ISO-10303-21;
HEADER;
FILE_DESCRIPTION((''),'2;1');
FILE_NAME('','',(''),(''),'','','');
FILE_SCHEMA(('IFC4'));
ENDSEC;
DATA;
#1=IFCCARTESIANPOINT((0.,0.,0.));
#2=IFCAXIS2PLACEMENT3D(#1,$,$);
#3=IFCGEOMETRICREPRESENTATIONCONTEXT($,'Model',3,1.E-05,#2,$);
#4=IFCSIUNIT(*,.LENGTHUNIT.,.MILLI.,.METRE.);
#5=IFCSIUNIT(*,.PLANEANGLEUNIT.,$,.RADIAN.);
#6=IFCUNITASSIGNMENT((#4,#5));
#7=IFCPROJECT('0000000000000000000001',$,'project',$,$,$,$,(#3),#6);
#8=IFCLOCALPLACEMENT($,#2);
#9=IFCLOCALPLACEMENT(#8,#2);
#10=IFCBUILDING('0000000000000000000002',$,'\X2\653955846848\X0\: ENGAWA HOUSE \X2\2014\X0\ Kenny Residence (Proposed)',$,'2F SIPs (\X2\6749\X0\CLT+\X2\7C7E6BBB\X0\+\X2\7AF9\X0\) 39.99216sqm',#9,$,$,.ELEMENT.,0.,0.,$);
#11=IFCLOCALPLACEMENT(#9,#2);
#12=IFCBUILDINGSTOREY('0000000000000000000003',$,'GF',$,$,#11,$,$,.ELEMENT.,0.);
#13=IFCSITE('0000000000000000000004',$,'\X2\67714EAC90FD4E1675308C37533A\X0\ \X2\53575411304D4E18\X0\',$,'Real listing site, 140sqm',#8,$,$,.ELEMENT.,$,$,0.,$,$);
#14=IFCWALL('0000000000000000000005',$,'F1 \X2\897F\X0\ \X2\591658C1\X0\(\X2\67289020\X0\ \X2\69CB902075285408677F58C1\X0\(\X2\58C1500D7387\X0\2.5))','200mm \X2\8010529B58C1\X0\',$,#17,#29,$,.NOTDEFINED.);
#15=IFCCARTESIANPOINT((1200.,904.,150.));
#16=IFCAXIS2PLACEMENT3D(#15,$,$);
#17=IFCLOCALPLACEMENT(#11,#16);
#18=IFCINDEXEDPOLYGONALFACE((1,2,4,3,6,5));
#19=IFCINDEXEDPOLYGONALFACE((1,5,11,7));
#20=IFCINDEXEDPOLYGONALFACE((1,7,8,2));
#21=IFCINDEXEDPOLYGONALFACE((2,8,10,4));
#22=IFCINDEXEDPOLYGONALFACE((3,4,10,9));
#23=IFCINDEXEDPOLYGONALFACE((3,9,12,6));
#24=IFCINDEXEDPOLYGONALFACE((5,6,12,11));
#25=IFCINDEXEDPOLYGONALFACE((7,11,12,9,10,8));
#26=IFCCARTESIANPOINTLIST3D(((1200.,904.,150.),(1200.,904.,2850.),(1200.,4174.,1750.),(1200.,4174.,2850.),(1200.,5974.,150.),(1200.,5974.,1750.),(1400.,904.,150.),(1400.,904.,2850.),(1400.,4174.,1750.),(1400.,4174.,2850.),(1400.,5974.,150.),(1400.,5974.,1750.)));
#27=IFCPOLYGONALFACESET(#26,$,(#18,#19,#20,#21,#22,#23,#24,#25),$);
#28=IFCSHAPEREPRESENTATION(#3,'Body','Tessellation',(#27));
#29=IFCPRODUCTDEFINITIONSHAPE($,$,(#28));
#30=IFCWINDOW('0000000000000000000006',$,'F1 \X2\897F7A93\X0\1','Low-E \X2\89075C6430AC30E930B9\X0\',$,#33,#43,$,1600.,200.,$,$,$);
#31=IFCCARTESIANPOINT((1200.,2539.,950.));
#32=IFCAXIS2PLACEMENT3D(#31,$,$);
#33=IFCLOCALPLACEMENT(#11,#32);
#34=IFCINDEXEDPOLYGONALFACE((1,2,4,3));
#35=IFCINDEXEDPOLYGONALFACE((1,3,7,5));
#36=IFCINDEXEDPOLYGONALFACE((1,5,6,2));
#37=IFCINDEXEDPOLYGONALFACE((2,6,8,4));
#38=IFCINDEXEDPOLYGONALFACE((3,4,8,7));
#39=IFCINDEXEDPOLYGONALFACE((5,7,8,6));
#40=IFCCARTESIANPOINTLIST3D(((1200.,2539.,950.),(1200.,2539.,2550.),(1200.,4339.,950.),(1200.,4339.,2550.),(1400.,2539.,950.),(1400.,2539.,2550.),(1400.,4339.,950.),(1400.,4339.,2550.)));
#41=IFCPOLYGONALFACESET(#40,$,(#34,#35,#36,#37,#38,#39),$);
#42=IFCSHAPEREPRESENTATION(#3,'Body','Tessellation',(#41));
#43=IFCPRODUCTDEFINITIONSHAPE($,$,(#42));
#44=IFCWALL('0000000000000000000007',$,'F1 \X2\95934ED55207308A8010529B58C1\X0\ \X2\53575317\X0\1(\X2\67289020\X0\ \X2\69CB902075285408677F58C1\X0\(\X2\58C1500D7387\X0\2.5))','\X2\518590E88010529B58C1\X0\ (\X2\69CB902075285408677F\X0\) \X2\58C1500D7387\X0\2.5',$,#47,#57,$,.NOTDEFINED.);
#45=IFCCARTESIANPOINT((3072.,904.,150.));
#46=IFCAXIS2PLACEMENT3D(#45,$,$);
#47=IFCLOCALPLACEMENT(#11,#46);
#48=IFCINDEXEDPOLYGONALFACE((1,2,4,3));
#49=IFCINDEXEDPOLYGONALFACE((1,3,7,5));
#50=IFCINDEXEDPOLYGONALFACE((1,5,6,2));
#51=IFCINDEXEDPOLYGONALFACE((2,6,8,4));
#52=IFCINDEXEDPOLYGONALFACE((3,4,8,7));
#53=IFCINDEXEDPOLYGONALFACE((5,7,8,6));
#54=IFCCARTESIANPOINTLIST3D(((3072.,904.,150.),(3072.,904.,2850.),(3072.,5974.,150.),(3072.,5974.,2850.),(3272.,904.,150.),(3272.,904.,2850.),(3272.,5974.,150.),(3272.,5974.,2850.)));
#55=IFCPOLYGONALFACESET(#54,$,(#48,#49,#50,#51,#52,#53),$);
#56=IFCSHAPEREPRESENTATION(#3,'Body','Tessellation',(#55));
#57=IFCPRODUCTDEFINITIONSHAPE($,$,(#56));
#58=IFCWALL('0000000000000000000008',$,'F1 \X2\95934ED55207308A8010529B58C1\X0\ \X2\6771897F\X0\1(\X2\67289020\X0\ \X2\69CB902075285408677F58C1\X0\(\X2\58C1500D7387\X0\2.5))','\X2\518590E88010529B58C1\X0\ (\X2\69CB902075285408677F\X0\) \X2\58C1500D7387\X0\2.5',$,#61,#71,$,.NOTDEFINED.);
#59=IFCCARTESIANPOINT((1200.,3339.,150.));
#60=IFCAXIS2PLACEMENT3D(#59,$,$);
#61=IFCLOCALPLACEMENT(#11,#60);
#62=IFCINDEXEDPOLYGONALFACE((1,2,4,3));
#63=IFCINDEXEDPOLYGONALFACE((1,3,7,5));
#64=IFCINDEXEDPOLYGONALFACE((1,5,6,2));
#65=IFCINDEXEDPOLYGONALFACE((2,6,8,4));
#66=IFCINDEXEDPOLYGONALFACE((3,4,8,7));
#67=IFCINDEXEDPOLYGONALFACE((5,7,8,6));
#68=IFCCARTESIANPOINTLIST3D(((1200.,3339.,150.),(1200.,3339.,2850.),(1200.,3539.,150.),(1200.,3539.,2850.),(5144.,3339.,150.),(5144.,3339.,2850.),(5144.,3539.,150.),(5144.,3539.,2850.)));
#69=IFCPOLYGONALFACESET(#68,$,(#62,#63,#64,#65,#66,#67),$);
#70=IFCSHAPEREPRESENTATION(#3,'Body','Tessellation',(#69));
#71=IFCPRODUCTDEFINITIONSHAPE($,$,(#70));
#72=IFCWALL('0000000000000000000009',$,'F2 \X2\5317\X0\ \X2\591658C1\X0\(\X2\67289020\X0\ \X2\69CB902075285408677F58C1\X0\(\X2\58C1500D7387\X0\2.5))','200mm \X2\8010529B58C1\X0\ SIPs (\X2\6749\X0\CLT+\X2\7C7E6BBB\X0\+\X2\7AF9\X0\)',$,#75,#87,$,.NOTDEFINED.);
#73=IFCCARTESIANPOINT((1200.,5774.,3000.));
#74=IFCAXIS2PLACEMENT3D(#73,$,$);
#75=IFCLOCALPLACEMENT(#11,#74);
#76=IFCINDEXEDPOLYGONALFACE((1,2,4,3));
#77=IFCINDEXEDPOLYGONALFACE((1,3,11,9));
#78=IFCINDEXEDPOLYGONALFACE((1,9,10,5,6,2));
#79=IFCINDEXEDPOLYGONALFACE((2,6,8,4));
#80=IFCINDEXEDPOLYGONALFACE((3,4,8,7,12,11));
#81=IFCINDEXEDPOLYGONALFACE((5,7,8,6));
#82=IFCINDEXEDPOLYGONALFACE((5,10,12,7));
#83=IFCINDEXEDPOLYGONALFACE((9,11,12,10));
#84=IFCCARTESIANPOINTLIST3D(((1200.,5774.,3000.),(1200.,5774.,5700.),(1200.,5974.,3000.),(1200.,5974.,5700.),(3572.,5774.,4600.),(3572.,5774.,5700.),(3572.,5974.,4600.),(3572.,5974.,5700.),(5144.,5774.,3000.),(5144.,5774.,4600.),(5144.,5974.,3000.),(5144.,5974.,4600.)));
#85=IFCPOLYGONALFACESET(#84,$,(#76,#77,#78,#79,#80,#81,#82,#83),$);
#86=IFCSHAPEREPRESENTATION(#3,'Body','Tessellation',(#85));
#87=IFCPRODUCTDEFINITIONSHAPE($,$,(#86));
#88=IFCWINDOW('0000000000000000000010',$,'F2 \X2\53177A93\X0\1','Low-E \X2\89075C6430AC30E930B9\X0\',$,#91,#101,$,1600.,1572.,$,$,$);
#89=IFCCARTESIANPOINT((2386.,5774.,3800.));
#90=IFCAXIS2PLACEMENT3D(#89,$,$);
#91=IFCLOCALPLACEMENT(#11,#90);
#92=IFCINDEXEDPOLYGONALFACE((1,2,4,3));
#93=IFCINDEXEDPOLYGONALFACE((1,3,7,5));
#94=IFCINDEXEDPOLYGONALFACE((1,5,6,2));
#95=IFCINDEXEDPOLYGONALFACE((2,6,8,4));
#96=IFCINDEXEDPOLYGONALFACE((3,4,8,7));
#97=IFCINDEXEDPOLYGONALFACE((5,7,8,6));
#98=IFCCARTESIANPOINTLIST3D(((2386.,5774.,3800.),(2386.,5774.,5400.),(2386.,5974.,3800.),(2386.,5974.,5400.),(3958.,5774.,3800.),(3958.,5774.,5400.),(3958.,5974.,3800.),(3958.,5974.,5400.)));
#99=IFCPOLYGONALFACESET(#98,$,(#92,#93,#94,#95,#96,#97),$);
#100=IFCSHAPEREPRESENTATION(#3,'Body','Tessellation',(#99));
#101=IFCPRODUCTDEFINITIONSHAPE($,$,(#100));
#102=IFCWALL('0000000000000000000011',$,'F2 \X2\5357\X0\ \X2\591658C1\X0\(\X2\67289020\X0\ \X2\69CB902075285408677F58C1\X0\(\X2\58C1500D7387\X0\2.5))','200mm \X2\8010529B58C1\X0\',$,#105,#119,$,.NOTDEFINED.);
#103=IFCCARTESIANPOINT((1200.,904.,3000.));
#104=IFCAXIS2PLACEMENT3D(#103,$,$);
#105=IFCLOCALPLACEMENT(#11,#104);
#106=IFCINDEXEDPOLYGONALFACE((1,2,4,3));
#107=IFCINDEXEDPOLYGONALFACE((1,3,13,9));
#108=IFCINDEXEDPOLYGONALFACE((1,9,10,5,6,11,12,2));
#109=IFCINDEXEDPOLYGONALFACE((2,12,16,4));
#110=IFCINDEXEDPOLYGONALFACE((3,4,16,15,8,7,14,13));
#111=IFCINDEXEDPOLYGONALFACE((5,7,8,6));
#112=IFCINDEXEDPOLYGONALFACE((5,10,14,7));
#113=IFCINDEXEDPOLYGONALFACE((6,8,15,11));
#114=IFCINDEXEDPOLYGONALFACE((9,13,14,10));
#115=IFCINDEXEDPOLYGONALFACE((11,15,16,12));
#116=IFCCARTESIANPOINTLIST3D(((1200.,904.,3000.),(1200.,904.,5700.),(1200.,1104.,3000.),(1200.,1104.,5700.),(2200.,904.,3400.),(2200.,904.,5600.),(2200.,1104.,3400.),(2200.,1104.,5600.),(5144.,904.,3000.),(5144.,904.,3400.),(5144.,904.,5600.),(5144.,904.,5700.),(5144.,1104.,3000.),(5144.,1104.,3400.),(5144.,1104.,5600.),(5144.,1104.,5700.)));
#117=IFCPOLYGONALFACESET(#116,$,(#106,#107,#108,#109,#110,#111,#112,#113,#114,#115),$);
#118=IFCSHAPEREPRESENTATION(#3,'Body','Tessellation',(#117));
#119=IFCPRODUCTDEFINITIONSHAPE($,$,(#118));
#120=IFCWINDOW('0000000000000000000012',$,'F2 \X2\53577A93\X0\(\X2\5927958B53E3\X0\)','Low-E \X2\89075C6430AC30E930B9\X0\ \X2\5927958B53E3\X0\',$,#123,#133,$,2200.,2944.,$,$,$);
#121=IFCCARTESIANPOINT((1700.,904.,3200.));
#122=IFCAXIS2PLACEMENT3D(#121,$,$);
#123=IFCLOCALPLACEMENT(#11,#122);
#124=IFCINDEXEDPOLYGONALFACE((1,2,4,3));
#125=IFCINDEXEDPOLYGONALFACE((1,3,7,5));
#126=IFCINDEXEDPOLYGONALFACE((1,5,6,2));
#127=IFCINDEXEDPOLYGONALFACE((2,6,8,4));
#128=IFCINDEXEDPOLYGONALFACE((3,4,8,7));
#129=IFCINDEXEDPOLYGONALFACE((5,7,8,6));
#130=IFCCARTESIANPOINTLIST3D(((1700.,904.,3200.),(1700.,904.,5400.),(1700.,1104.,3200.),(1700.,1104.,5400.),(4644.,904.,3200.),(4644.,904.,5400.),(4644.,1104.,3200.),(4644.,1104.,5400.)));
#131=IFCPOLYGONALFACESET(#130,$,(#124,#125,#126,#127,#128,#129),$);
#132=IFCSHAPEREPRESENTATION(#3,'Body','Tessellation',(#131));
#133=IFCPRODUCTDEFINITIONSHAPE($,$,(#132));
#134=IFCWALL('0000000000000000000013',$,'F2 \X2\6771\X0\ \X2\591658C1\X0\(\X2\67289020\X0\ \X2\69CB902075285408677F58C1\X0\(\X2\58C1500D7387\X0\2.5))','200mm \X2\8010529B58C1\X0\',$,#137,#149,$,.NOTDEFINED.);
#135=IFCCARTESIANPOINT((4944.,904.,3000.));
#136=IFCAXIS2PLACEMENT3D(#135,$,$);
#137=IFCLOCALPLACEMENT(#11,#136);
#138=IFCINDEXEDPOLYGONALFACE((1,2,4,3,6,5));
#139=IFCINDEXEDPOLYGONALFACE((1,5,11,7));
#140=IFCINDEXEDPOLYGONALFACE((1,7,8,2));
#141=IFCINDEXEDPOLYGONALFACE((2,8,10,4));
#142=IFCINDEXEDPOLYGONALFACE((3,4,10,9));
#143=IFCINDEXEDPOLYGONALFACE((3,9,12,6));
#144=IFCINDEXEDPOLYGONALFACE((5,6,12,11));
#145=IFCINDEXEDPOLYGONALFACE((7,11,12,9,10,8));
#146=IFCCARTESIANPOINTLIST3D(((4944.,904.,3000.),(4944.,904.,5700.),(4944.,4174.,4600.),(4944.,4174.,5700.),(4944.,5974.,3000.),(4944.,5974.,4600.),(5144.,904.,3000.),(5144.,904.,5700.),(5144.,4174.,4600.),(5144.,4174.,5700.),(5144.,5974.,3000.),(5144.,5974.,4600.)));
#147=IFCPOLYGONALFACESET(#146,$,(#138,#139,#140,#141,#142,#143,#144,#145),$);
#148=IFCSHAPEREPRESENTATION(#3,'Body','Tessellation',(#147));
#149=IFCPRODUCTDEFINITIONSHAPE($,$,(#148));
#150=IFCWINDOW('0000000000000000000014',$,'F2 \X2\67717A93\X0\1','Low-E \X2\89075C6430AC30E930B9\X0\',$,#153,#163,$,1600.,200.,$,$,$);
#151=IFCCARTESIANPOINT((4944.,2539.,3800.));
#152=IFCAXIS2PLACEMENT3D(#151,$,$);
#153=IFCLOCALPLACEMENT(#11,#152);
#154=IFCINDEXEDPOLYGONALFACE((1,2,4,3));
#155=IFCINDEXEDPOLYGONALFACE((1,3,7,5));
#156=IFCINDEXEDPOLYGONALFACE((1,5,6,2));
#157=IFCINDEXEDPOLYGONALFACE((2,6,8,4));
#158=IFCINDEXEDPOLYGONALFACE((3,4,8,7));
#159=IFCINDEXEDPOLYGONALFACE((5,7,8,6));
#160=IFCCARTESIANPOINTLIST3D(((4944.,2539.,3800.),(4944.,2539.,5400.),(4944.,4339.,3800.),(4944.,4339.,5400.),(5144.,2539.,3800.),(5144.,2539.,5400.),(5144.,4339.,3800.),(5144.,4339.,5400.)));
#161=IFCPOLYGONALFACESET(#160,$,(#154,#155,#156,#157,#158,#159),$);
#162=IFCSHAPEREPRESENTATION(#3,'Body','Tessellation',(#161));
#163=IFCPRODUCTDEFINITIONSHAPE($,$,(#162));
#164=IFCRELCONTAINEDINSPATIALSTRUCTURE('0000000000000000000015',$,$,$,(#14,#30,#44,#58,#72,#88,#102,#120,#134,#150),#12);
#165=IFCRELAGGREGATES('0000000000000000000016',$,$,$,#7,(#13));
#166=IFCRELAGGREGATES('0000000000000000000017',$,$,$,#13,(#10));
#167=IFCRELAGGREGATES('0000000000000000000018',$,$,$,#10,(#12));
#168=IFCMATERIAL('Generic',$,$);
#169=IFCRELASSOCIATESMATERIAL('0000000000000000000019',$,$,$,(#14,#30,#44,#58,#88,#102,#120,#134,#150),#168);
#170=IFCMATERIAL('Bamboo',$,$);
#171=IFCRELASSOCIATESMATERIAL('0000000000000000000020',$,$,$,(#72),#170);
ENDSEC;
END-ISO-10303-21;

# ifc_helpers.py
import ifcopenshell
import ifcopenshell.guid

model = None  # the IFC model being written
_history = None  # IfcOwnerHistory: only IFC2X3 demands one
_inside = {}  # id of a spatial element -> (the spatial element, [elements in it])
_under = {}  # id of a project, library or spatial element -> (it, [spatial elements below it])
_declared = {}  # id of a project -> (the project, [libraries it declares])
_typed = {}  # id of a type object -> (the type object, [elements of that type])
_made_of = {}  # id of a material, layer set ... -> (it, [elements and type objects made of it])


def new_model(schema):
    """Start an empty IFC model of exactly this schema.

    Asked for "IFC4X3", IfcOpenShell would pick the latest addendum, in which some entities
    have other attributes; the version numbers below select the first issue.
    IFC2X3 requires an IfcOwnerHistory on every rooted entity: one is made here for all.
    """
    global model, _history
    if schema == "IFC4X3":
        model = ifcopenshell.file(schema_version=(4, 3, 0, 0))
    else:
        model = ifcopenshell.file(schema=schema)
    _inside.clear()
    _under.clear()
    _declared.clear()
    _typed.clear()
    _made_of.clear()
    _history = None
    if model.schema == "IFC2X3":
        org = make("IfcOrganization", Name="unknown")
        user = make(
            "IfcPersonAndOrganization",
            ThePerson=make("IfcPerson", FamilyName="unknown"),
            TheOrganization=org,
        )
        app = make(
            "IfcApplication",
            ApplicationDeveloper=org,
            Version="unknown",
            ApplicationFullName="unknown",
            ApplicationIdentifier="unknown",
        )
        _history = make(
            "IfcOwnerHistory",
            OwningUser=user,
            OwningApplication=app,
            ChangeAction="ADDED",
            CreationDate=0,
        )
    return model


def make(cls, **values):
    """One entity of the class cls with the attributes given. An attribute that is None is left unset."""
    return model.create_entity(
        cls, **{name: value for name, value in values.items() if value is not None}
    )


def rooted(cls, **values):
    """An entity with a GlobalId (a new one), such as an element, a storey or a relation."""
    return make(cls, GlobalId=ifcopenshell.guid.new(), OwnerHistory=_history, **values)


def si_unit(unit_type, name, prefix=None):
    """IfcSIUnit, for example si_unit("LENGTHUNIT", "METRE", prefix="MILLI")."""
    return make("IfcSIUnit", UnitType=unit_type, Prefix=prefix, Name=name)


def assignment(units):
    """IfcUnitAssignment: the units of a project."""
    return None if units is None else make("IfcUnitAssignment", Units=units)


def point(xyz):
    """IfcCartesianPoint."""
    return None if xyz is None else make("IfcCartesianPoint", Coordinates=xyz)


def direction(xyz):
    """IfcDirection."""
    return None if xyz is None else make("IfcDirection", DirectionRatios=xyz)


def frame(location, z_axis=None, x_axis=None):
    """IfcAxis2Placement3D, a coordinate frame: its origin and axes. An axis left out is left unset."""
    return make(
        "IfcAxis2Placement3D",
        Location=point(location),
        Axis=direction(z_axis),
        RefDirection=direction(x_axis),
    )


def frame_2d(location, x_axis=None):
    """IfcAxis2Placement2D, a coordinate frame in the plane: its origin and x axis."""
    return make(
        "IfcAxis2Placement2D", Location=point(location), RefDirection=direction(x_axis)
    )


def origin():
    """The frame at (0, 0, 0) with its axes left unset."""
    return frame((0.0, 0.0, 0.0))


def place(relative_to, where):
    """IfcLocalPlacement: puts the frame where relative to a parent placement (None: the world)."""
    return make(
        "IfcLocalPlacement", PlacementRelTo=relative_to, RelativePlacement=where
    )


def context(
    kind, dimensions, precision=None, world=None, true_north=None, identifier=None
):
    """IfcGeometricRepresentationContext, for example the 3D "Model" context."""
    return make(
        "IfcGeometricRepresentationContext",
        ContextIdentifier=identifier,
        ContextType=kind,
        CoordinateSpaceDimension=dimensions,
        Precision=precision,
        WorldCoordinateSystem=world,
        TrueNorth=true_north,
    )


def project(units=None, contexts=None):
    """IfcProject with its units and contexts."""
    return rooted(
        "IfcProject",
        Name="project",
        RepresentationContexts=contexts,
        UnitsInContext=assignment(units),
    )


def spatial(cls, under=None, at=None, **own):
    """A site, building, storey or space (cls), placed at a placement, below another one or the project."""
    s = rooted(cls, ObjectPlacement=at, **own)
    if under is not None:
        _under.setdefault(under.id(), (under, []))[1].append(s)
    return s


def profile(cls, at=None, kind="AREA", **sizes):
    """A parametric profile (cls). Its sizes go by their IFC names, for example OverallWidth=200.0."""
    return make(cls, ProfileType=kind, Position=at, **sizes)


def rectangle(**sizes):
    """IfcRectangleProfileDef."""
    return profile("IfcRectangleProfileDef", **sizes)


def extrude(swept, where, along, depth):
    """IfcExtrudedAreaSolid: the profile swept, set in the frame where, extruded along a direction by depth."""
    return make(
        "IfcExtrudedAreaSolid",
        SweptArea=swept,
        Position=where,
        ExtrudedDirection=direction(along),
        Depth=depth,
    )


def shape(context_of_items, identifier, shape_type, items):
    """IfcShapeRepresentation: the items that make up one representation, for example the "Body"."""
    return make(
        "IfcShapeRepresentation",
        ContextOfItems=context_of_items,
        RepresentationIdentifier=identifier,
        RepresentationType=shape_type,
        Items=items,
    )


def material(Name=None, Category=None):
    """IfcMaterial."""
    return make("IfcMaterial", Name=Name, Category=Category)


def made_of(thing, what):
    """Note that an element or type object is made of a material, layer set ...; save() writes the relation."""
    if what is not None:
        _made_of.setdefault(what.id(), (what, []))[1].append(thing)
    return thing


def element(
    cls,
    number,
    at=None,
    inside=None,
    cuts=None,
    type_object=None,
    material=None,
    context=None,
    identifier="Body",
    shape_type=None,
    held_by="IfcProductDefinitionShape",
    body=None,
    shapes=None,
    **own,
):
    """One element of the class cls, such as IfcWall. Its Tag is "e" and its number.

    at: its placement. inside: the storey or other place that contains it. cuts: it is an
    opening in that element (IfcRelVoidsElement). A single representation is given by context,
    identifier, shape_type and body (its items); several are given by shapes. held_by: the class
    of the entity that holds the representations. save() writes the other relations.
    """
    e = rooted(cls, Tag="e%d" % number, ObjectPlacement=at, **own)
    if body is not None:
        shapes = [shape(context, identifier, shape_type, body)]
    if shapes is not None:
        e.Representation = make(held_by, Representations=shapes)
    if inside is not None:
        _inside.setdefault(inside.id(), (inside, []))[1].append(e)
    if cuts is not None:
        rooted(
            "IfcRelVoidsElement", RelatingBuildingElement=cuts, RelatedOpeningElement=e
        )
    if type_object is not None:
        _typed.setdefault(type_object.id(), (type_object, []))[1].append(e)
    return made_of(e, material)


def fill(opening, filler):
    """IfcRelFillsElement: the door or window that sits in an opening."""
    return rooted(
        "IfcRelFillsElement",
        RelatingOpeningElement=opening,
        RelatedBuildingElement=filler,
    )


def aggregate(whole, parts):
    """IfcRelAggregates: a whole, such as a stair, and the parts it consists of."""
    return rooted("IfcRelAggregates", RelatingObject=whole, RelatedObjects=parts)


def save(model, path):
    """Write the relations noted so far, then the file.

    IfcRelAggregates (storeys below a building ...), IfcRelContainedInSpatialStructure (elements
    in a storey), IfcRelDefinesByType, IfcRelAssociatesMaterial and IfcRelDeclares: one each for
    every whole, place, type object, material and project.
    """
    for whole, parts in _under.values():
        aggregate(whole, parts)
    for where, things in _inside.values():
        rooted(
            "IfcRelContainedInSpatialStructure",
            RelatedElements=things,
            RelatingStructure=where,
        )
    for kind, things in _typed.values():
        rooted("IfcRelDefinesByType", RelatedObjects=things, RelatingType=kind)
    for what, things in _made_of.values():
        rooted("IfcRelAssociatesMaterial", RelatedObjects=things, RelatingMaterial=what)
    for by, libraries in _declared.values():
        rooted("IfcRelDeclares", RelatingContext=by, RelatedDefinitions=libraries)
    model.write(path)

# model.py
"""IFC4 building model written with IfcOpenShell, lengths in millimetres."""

from ifc_helpers import new_model, si_unit, frame, frame_2d, origin, place, context, project, spatial, rectangle, extrude, material, element, fill, save


model = new_model("IFC4")

# Units and contexts
model_context = context("Model", 3, precision=1e-05, world=origin())
ifc_project = project(units=[si_unit("LENGTHUNIT", "METRE", prefix="MILLI"), si_unit("PLANEANGLEUNIT", "RADIAN")], contexts=[model_context])

# Site, building, storey
site_placement = place(None, origin())
site = spatial("IfcSite", under=ifc_project, at=site_placement, Name="東京都世田谷区 南向き丘", ObjectType="Real listing site, 140sqm", CompositionType="ELEMENT", RefElevation=0.0)
building_placement = place(site_placement, origin())
building = spatial("IfcBuilding", under=site, at=building_placement, Name="改善案: ENGAWA HOUSE — Kenny Residence (Proposed)", ObjectType="2F SIPs (杉CLT+籾殻+竹) 39.99216sqm", CompositionType="ELEMENT", ElevationOfRefHeight=0.0, ElevationOfTerrain=0.0)
storey_placement = place(building_placement, origin())
storey = spatial("IfcBuildingStorey", under=building, at=storey_placement, Name="GF", CompositionType="ELEMENT", Elevation=0.0)

# Shared definitions
ifc_material_1 = material(Name="Generic")

# Shared definitions
ifc_material_2 = material(Name="Bamboo")

# Wall, opening, window
wall_1_placement = place(storey_placement, frame((1200.0, 904.0, 150.0)))
wall_1 = element("IfcWall", 1, at=wall_1_placement, inside=storey, material=ifc_material_1, Name="F1 西 外壁(木造 構造用合板壁(壁倍率2.5))", Description="200mm 耐力壁", PredefinedType="NOTDEFINED", context=model_context, shape_type="SweptSolid", body=[
    extrude(rectangle(XDim=200.0, YDim=5070.0, at=frame_2d((100.0, 2535.0))), frame((1200.0, 904.0, 150.0)), (0.0, 0.0, 1.0), 2700.0),
])
opening_1_placement = place(storey_placement, frame((1200.0, 2539.0, 950.0)))
opening_1 = element("IfcOpeningElement", 2, at=opening_1_placement, cuts=wall_1, PredefinedType="NOTDEFINED", context=model_context, shape_type="SweptSolid", body=[
    extrude(rectangle(XDim=200.0, YDim=1800.0, at=frame_2d((100.0, 900.0))), frame((1200.0, 2539.0, 950.0)), (0.0, 0.0, 1.0), 1600.0),
])
window_1_placement = place(storey_placement, frame((1200.0, 2539.0, 950.0)))
window_1 = element("IfcWindow", 3, at=window_1_placement, inside=storey, material=ifc_material_1, Name="F1 西窓1", Description="Low-E 複層ガラス", OverallHeight=1600.0, OverallWidth=200.0, context=model_context, shape_type="SweptSolid", body=[
    extrude(rectangle(XDim=200.0, YDim=1800.0, at=frame_2d((100.0, 900.0))), frame((1200.0, 2539.0, 950.0)), (0.0, 0.0, 1.0), 1600.0),
])
fill(opening_1, window_1)

# Walls
wall_2_placement = place(storey_placement, frame((3072.0, 904.0, 150.0)))
element("IfcWall", 4, at=wall_2_placement, inside=storey, material=ifc_material_1, Name="F1 間仕切り耐力壁 南北1(木造 構造用合板壁(壁倍率2.5))", Description="内部耐力壁 (構造用合板) 壁倍率2.5", PredefinedType="NOTDEFINED", context=model_context, shape_type="SweptSolid", body=[
    extrude(rectangle(XDim=200.0, YDim=5070.0, at=frame_2d((100.0, 2535.0))), frame((3072.0, 904.0, 150.0)), (0.0, 0.0, 1.0), 2700.0),
])
wall_3_placement = place(storey_placement, frame((1200.0, 3339.0, 150.0)))
element("IfcWall", 5, at=wall_3_placement, inside=storey, material=ifc_material_1, Name="F1 間仕切り耐力壁 東西1(木造 構造用合板壁(壁倍率2.5))", Description="内部耐力壁 (構造用合板) 壁倍率2.5", PredefinedType="NOTDEFINED", context=model_context, shape_type="SweptSolid", body=[
    extrude(rectangle(XDim=3944.0, YDim=200.0, at=frame_2d((1972.0, 100.0))), frame((1200.0, 3339.0, 150.0)), (0.0, 0.0, 1.0), 2700.0),
])

# Walls, openings, windows
wall_4_placement = place(storey_placement, frame((1200.0, 5774.0, 3000.0)))
wall_4 = element("IfcWall", 6, at=wall_4_placement, inside=storey, material=ifc_material_2, Name="F2 北 外壁(木造 構造用合板壁(壁倍率2.5))", Description="200mm 耐力壁 SIPs (杉CLT+籾殻+竹)", PredefinedType="NOTDEFINED", context=model_context, shape_type="SweptSolid", body=[
    extrude(rectangle(XDim=3944.0, YDim=200.0, at=frame_2d((1972.0, 100.0))), frame((1200.0, 5774.0, 3000.0)), (0.0, 0.0, 1.0), 2700.0),
])
opening_2_placement = place(storey_placement, frame((2386.0, 5774.0, 3800.0)))
opening_2 = element("IfcOpeningElement", 7, at=opening_2_placement, cuts=wall_4, PredefinedType="NOTDEFINED", context=model_context, shape_type="SweptSolid", body=[
    extrude(rectangle(XDim=1572.0, YDim=200.0, at=frame_2d((786.0, 100.0))), frame((2386.0, 5774.0, 3800.0)), (0.0, 0.0, 1.0), 1600.0),
])
window_2_placement = place(storey_placement, frame((2386.0, 5774.0, 3800.0)))
window_2 = element("IfcWindow", 8, at=window_2_placement, inside=storey, material=ifc_material_1, Name="F2 北窓1", Description="Low-E 複層ガラス", OverallHeight=1600.0, OverallWidth=1572.0, context=model_context, shape_type="SweptSolid", body=[
    extrude(rectangle(XDim=1572.0, YDim=200.0, at=frame_2d((786.0, 100.0))), frame((2386.0, 5774.0, 3800.0)), (0.0, 0.0, 1.0), 1600.0),
])
fill(opening_2, window_2)
wall_5_placement = place(storey_placement, frame((1200.0, 904.0, 3000.0)))
wall_5 = element("IfcWall", 9, at=wall_5_placement, inside=storey, material=ifc_material_1, Name="F2 南 外壁(木造 構造用合板壁(壁倍率2.5))", Description="200mm 耐力壁", PredefinedType="NOTDEFINED", context=model_context, shape_type="SweptSolid", body=[
    extrude(rectangle(XDim=3944.0, YDim=200.0, at=frame_2d((1972.0, 100.0))), frame((1200.0, 904.0, 3000.0)), (0.0, 0.0, 1.0), 2700.0),
])
opening_3_placement = place(storey_placement, frame((1700.0, 904.0, 3200.0)))
opening_3 = element("IfcOpeningElement", 10, at=opening_3_placement, cuts=wall_5, PredefinedType="NOTDEFINED", context=model_context, shape_type="SweptSolid", body=[
    extrude(rectangle(XDim=2944.0, YDim=200.0, at=frame_2d((1472.0, 100.0))), frame((1700.0, 904.0, 3200.0)), (0.0, 0.0, 1.0), 2200.0),
])
window_3_placement = place(storey_placement, frame((1700.0, 904.0, 3200.0)))
window_3 = element("IfcWindow", 11, at=window_3_placement, inside=storey, material=ifc_material_1, Name="F2 南窓(大開口)", Description="Low-E 複層ガラス 大開口", OverallHeight=2200.0, OverallWidth=2944.0, context=model_context, shape_type="SweptSolid", body=[
    extrude(rectangle(XDim=2944.0, YDim=200.0, at=frame_2d((1472.0, 100.0))), frame((1700.0, 904.0, 3200.0)), (0.0, 0.0, 1.0), 2200.0),
])
fill(opening_3, window_3)
wall_6_placement = place(storey_placement, frame((4944.0, 904.0, 3000.0)))
wall_6 = element("IfcWall", 12, at=wall_6_placement, inside=storey, material=ifc_material_1, Name="F2 東 外壁(木造 構造用合板壁(壁倍率2.5))", Description="200mm 耐力壁", PredefinedType="NOTDEFINED", context=model_context, shape_type="SweptSolid", body=[
    extrude(rectangle(XDim=200.0, YDim=5070.0, at=frame_2d((100.0, 2535.0))), frame((4944.0, 904.0, 3000.0)), (0.0, 0.0, 1.0), 2700.0),
])
opening_4_placement = place(storey_placement, frame((4944.0, 2539.0, 3800.0)))
opening_4 = element("IfcOpeningElement", 13, at=opening_4_placement, cuts=wall_6, PredefinedType="NOTDEFINED", context=model_context, shape_type="SweptSolid", body=[
    extrude(rectangle(XDim=200.0, YDim=1800.0, at=frame_2d((100.0, 900.0))), frame((4944.0, 2539.0, 3800.0)), (0.0, 0.0, 1.0), 1600.0),
])
window_4_placement = place(storey_placement, frame((4944.0, 2539.0, 3800.0)))
window_4 = element("IfcWindow", 14, at=window_4_placement, inside=storey, material=ifc_material_1, Name="F2 東窓1", Description="Low-E 複層ガラス", OverallHeight=1600.0, OverallWidth=200.0, context=model_context, shape_type="SweptSolid", body=[
    extrude(rectangle(XDim=200.0, YDim=1800.0, at=frame_2d((100.0, 900.0))), frame((4944.0, 2539.0, 3800.0)), (0.0, 0.0, 1.0), 1600.0),
])
fill(opening_4, window_4)

save(model, "model.ifc")
